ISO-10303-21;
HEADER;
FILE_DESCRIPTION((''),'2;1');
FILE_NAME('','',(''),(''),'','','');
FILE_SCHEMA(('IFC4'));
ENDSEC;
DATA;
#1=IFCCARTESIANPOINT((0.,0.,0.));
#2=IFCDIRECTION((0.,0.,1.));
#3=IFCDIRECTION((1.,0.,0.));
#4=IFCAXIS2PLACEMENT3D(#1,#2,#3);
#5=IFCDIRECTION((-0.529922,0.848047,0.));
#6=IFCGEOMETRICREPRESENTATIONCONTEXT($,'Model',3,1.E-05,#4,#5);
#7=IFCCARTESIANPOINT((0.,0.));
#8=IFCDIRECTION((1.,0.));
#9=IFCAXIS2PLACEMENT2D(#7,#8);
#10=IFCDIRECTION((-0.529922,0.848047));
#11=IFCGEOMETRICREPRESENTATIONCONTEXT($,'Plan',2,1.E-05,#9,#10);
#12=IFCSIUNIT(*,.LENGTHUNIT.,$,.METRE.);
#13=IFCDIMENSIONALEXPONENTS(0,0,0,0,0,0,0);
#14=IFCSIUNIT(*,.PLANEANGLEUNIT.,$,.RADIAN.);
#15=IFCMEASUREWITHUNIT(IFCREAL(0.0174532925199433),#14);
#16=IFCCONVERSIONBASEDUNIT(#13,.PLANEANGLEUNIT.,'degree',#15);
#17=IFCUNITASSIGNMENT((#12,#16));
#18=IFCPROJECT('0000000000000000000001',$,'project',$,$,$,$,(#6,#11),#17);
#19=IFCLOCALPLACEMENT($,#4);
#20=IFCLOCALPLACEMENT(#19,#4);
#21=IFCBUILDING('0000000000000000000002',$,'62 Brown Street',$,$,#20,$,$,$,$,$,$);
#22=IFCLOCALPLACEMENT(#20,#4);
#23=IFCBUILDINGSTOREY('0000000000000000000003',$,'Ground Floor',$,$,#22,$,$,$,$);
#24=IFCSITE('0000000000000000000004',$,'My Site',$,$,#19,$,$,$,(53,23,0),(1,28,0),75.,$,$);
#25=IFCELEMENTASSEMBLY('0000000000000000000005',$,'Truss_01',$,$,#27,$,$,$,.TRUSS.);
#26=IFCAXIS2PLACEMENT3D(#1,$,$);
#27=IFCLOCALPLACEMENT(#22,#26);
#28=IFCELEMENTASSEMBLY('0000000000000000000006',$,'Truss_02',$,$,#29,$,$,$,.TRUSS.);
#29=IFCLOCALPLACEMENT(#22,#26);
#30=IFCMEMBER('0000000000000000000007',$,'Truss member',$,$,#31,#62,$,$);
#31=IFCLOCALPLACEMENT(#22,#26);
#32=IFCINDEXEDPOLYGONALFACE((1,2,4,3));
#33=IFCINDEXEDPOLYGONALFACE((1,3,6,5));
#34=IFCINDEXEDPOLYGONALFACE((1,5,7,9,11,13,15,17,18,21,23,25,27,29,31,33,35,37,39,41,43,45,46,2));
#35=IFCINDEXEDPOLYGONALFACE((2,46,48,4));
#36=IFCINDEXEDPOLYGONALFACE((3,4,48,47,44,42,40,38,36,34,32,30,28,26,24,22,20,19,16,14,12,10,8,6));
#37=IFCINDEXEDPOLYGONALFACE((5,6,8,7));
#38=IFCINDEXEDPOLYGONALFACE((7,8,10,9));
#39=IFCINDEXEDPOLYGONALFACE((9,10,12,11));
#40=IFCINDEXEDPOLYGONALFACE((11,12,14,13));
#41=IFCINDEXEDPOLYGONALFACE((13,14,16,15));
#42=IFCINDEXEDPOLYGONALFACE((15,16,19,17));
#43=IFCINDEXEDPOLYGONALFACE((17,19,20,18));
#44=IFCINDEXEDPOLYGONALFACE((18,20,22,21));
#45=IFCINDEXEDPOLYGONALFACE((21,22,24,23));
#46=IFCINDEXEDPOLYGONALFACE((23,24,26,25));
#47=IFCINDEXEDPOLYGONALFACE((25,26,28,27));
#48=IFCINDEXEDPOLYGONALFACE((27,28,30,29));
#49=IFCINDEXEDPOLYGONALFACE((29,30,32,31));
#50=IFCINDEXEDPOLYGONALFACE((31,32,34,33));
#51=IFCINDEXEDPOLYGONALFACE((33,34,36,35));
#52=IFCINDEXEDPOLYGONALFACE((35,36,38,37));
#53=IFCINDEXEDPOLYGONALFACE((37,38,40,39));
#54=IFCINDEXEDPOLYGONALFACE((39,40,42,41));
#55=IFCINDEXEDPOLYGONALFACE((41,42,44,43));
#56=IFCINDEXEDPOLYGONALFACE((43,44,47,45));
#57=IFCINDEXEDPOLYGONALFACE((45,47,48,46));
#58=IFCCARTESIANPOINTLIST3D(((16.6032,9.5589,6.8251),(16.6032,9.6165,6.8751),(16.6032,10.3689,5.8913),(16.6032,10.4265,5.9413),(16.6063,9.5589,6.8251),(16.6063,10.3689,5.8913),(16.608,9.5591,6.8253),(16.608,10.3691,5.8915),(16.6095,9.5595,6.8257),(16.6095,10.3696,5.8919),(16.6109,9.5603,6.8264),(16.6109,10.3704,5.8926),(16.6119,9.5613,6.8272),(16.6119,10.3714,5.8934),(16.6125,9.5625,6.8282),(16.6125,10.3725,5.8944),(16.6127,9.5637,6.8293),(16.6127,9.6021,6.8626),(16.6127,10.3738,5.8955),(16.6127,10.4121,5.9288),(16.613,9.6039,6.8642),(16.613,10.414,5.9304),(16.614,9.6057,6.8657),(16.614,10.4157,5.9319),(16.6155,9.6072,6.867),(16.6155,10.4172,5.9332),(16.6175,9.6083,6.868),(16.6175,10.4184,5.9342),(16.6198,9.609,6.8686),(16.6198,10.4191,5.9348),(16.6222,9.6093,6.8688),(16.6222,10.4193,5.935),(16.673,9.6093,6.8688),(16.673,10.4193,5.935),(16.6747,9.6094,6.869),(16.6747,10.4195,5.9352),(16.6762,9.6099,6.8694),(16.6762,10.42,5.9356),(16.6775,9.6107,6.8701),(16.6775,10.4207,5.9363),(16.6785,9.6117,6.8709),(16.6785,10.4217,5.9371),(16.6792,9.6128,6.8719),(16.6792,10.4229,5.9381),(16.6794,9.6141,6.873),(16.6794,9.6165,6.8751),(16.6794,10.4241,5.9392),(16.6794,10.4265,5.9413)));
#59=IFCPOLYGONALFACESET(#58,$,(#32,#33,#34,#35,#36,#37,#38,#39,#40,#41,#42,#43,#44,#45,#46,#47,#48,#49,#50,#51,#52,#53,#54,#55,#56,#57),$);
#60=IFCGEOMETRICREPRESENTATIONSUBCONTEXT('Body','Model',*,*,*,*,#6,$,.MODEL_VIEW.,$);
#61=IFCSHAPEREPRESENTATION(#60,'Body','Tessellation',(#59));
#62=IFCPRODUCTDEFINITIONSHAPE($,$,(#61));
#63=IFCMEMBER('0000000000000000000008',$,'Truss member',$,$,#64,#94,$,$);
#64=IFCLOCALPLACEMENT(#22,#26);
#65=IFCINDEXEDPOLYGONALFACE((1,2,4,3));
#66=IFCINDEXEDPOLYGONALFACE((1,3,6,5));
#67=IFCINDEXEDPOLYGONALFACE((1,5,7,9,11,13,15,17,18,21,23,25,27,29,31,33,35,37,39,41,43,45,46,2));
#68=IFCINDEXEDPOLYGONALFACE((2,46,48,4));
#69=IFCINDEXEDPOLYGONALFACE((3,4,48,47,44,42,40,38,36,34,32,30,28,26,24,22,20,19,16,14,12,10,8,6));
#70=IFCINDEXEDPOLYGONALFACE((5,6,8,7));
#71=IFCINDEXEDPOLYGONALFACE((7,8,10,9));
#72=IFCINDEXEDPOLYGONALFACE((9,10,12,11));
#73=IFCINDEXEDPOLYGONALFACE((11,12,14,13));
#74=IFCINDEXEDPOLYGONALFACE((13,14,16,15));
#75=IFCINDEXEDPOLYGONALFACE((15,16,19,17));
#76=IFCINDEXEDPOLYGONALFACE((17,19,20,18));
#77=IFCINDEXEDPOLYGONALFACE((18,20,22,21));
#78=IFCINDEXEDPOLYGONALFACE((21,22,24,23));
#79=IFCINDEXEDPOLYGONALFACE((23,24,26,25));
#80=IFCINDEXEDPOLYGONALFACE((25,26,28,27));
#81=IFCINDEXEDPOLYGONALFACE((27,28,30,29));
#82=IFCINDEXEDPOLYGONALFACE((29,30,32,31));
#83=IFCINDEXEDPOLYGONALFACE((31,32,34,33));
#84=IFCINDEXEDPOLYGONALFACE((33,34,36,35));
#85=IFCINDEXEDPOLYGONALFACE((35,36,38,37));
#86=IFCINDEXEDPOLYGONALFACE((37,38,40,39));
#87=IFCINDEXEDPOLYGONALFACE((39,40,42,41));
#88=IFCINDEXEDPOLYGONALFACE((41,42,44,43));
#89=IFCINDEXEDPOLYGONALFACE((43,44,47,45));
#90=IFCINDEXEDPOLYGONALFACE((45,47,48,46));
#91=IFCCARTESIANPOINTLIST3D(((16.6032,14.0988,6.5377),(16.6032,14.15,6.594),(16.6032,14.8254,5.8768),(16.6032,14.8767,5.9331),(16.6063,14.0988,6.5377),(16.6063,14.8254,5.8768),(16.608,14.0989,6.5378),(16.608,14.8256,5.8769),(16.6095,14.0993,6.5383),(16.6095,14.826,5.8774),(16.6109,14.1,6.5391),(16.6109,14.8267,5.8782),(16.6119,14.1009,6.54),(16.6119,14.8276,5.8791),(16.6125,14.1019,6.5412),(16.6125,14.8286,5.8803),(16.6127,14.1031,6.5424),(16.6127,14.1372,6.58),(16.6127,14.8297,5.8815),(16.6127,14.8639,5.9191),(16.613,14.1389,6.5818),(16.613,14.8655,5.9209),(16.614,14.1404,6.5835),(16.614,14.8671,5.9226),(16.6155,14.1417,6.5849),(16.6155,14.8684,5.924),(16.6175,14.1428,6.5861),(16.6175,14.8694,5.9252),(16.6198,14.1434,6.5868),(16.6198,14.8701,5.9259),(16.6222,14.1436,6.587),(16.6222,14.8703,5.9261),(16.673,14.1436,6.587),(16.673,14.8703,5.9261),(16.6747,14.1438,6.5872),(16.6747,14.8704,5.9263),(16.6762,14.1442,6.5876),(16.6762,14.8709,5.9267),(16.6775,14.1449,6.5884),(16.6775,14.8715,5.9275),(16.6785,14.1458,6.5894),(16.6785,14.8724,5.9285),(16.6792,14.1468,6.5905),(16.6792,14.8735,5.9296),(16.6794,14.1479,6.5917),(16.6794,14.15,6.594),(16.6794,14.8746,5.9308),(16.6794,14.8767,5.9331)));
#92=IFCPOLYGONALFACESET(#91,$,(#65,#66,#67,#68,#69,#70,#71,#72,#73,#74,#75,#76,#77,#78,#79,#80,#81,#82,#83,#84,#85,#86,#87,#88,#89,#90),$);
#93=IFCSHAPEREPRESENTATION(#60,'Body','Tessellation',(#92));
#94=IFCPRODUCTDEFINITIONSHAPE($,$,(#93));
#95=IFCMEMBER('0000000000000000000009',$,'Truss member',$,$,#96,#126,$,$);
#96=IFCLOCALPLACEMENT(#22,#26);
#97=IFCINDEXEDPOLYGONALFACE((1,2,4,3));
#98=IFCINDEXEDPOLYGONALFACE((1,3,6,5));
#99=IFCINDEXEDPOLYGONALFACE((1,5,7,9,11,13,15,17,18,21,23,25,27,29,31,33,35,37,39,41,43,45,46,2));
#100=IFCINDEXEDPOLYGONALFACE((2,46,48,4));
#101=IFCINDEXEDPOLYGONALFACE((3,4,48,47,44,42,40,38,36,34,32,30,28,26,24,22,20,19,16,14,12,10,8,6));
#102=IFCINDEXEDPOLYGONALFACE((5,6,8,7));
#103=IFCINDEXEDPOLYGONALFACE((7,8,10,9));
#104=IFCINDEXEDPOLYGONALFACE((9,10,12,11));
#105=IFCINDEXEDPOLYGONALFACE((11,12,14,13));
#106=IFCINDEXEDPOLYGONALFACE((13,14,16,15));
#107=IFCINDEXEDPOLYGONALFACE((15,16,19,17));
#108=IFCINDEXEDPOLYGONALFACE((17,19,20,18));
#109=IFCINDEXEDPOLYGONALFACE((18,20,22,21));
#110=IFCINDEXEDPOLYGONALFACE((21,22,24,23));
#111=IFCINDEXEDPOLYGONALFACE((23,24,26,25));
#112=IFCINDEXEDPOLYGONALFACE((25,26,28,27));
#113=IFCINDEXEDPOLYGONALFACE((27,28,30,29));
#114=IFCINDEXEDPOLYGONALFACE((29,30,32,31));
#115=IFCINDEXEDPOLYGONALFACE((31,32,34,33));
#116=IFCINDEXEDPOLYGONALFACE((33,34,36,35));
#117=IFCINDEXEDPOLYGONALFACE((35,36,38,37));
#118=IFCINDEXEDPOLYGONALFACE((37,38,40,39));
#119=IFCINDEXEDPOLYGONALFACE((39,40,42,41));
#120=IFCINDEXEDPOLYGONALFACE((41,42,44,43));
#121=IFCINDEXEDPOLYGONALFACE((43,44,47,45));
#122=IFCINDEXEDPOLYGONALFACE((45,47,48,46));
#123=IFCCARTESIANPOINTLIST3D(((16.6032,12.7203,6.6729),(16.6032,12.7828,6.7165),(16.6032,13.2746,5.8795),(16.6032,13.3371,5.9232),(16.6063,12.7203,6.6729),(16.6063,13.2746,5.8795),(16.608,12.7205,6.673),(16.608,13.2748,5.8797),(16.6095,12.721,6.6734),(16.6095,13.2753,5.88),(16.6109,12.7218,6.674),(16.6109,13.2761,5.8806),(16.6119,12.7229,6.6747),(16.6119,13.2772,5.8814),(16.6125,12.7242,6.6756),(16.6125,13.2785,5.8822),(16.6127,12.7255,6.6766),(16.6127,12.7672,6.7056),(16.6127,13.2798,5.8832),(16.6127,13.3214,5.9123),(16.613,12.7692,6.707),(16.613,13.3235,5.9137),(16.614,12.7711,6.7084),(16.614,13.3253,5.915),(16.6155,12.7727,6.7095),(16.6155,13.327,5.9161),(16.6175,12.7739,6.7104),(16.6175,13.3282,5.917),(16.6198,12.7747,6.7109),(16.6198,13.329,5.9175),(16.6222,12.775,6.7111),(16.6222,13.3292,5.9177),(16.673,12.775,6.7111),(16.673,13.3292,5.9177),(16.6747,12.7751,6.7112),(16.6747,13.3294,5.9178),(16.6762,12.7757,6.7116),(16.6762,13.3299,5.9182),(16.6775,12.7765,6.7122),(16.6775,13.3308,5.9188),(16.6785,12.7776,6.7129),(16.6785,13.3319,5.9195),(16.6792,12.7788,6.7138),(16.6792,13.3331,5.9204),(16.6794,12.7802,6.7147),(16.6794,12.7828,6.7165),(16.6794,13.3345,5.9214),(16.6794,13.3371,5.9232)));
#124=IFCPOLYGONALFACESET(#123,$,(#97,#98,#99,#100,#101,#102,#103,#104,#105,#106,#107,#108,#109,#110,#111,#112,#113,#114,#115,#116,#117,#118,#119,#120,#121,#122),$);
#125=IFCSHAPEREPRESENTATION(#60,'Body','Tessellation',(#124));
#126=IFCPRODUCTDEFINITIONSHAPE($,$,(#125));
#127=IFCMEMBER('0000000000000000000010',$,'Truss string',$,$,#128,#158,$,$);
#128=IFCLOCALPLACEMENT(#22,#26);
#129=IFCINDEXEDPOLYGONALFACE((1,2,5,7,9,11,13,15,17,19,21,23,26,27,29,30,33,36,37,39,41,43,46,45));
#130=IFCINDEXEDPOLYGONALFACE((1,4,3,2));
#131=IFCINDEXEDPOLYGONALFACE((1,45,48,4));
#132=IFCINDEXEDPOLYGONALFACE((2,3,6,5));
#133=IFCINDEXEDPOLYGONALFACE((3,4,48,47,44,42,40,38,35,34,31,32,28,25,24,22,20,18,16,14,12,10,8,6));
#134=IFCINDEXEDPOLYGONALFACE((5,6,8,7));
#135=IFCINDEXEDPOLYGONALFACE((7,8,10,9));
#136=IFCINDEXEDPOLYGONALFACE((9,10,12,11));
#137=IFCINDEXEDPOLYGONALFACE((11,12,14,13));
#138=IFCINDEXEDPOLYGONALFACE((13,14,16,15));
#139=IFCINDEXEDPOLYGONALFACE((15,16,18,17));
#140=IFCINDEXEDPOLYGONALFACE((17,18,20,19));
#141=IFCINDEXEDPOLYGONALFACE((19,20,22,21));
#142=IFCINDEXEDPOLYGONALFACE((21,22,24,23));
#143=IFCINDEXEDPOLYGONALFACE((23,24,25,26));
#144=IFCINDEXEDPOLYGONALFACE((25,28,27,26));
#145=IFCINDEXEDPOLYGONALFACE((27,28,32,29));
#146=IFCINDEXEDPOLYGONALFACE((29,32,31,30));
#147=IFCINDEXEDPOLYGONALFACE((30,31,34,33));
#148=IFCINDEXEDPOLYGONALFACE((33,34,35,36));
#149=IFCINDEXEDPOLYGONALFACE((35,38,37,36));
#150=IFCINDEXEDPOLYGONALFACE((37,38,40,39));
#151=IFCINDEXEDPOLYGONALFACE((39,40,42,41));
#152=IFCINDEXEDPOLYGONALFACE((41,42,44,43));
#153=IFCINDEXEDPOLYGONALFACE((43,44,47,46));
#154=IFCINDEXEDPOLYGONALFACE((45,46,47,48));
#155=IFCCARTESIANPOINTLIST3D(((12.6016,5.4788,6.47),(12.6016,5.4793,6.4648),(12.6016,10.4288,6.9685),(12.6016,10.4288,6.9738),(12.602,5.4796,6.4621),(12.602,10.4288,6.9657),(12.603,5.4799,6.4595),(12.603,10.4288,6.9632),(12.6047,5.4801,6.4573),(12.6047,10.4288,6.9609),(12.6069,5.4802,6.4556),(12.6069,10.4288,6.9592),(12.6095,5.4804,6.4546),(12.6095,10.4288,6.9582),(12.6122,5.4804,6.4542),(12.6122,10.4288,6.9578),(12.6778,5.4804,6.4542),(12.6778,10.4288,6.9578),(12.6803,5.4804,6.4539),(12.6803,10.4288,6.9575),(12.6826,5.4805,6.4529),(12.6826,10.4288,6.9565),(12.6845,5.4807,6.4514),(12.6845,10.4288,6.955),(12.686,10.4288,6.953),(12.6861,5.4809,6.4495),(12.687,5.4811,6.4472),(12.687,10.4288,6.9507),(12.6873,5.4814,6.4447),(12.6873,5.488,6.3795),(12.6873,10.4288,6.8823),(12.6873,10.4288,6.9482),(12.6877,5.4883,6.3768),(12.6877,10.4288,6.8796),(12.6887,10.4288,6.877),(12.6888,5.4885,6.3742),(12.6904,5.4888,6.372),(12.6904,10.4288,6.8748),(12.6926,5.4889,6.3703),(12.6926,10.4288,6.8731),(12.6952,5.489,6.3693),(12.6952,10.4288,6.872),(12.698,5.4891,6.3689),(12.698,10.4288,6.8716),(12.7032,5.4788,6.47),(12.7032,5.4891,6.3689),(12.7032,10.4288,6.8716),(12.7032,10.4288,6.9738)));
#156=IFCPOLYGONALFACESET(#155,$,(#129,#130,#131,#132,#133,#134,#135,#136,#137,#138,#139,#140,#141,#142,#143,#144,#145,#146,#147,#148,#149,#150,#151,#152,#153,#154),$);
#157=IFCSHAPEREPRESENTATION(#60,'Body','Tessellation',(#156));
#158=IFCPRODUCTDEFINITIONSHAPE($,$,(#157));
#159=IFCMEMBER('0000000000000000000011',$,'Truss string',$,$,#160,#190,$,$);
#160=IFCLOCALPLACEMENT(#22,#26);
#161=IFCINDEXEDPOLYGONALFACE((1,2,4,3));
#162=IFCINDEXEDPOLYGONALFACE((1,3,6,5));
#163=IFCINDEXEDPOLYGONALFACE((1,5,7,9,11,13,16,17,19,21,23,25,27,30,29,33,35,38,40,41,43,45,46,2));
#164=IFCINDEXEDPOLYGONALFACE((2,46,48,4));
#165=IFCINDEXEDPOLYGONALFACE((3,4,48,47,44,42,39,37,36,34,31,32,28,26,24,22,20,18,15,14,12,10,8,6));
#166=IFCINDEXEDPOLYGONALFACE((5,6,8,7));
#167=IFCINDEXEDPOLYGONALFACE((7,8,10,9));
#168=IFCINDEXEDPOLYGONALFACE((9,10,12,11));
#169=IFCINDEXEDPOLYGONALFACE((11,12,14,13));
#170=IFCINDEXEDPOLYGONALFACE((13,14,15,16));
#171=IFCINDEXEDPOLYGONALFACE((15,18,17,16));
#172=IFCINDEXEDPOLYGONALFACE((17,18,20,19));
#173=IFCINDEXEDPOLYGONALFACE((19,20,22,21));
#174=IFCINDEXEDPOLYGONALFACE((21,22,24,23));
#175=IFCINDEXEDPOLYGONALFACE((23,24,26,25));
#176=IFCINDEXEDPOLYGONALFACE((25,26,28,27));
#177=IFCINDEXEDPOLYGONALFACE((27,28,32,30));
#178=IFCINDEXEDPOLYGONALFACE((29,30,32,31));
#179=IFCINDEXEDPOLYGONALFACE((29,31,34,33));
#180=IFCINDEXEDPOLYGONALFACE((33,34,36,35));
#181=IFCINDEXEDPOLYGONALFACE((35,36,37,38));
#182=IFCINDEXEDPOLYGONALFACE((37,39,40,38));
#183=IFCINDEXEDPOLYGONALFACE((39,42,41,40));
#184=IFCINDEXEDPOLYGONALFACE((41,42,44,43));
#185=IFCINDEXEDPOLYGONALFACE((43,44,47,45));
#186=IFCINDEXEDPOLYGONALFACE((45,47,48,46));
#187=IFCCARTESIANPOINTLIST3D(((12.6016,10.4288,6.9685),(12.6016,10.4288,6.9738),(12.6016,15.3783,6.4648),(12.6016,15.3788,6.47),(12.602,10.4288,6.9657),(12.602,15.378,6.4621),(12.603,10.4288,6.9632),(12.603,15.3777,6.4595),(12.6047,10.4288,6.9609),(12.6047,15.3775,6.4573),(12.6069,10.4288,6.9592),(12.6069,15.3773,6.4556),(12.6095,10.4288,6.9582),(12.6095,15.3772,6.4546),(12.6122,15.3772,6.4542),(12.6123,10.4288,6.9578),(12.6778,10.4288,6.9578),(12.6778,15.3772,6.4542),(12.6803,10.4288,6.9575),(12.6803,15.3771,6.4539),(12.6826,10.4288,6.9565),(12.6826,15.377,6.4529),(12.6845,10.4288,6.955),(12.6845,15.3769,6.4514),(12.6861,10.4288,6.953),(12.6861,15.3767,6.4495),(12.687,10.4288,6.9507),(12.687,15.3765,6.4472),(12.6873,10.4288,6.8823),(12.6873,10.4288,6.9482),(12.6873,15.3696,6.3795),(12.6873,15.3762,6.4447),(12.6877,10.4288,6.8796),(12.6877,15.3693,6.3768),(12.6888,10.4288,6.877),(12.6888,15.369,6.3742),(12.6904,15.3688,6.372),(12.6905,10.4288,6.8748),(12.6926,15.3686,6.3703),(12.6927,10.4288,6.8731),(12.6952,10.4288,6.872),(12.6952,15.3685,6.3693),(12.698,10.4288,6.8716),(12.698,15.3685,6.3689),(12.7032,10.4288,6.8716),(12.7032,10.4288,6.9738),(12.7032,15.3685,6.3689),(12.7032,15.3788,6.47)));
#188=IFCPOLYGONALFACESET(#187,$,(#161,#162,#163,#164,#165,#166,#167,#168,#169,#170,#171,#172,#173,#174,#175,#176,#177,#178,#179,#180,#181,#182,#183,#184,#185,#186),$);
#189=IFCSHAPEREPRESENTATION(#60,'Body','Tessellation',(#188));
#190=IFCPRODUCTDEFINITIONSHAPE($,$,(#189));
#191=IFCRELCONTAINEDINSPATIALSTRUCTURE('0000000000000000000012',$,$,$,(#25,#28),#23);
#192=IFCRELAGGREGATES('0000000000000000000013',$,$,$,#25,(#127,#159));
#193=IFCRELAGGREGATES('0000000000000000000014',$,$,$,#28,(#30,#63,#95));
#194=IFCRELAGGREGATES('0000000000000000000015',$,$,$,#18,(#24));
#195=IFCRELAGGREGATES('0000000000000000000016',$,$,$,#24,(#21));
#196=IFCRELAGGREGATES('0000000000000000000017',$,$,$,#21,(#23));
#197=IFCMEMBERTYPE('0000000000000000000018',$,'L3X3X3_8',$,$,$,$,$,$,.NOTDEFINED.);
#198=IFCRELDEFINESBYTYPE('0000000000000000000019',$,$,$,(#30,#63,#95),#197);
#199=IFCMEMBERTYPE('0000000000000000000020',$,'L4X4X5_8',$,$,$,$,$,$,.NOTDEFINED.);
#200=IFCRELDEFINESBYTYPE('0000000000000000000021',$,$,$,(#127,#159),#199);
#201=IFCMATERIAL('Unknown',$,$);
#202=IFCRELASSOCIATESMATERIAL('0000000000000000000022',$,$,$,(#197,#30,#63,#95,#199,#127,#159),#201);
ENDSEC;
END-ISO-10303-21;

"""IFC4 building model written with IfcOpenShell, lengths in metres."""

from ifc_helpers import new_model, entity, si_unit, converted_unit, direction, frame, origin_with_axes, origin_2d_with_axis, place, context, subcontext, project, spatial, l_section, extrude, clip, halfspace, material, material_profile, profile_set, profile_usage, type_object, element, aggregate, save


model = new_model("IFC4")

# Units and contexts
model_context = context("Model", 3, precision=1e-05, world=origin_with_axes(), true_north=direction((-0.529922, 0.848047, 0.0)))
plan_context = context("Plan", 2, precision=1e-05, world=origin_2d_with_axis(), true_north=direction((-0.529922, 0.848047)))
body_context = subcontext(model_context, "Body", "Model", "MODEL_VIEW")
ifc_project = project(units=[si_unit("LENGTHUNIT", "METRE"), converted_unit("PLANEANGLEUNIT", "degree", entity("IfcReal", 0.0174532925199433), si_unit("PLANEANGLEUNIT", "RADIAN"), dimensions=[0, 0, 0, 0, 0, 0, 0])], contexts=[model_context, plan_context])

# Site, building, storey
site_placement = place(None, origin_with_axes())
site = spatial("IfcSite", under=ifc_project, at=site_placement, Name="My Site", RefLatitude=(53, 23, 0), RefLongitude=(1, 28, 0), RefElevation=75.0)
building_placement = place(site_placement, origin_with_axes())
building = spatial("IfcBuilding", under=site, at=building_placement, Name="62 Brown Street")
storey_placement = place(building_placement, origin_with_axes())
storey = spatial("IfcBuildingStorey", under=building, at=storey_placement, Name="Ground Floor")

# Element assemblies, members
ifc_material_1 = material(Name="Unknown")
ifc_material_profile_1 = material_profile(ifc_material_1, l_section(Depth=0.0762, Width=0.0762, Thickness=0.0095, FilletRadius=0.0095, EdgeRadius=0.0064))
ifc_profile_set_1 = profile_set([ifc_material_profile_1])
member_type_1 = type_object("IfcMemberType", Name="L3X3X3_8", PredefinedType="NOTDEFINED", material=ifc_profile_set_1)
assembly_1_placement = place(storey_placement, frame((12.7032, 10.4288, 6.9738), z_axis=(0.0, 0.0, 1.0), x_axis=(1.0, 0.0, 0.0)))
assembly_1 = element("IfcElementAssembly", 1, at=assembly_1_placement, inside=storey, Name="Truss_01", PredefinedType="TRUSS")
assembly_2_placement = place(storey_placement, frame((16.6032, 10.4288, 6.9738), z_axis=(0.0, 0.0, 1.0), x_axis=(1.0, 0.0, 0.0)))
assembly_2 = element("IfcElementAssembly", 2, at=assembly_2_placement, inside=storey, Name="Truss_02", PredefinedType="TRUSS")
ifc_profile_usage_1 = profile_usage(ifc_profile_set_1, cardinal=5)
member_1_placement = place(assembly_2_placement, frame((0.0381, -0.8411, -0.1236), z_axis=(-0.000001, 0.655276, -0.755389), x_axis=(1.0, 0.000001, 0.0)))
member_1 = element("IfcMember", 3, at=member_1_placement, type_object=member_type_1, material=ifc_profile_usage_1, Name="Truss member", context=body_context, shape_type="SweptSolid", body=[
    extrude(l_section(Depth=0.0762, Width=0.0762, Thickness=0.0095, FilletRadius=0.0095, EdgeRadius=0.0064), origin_with_axes(), (0.0, 0.0, 1.0), 1.2362),
])
ifc_profile_usage_2 = profile_usage(ifc_profile_set_1, cardinal=5)
member_2_placement = place(assembly_2_placement, frame((0.0381, 3.6956, -0.4079), z_axis=(-0.000001, 0.739785, -0.672843), x_axis=(1.0, 0.000001, 0.0)))
member_2 = element("IfcMember", 4, at=member_2_placement, type_object=member_type_1, material=ifc_profile_usage_2, Name="Truss member", context=body_context, shape_type="SweptSolid", body=[
    extrude(l_section(Depth=0.0762, Width=0.0762, Thickness=0.0095, FilletRadius=0.0095, EdgeRadius=0.0064), origin_with_axes(), (0.0, 0.0, 1.0), 0.9823),
])
ifc_profile_usage_3 = profile_usage(ifc_profile_set_1, cardinal=5)
member_3_placement = place(assembly_2_placement, frame((0.0381, 2.3228, -0.279), z_axis=(-0.000001, 0.572709, -0.819759), x_axis=(1.0, 0.0, 0.0)))
member_3 = element("IfcMember", 5, at=member_3_placement, type_object=member_type_1, material=ifc_profile_usage_3, Name="Truss member", context=body_context, shape_type="SweptSolid", body=[
    extrude(l_section(Depth=0.0762, Width=0.0762, Thickness=0.0095, FilletRadius=0.0095, EdgeRadius=0.0064), origin_with_axes(), (0.0, 0.0, 1.0), 0.9678),
])

# Members
ifc_material_profile_2 = material_profile(ifc_material_1, l_section(Depth=0.1016, Width=0.1016, Thickness=0.0159, FilletRadius=0.0095, EdgeRadius=0.0106))
ifc_profile_set_2 = profile_set([ifc_material_profile_2])
ifc_profile_usage_4 = profile_usage(ifc_profile_set_2, cardinal=5)
member_type_2 = type_object("IfcMemberType", Name="L4X4X5_8", PredefinedType="NOTDEFINED", material=ifc_profile_set_2)
member_4_placement = place(assembly_1_placement, frame((-0.0508, 0.3519, -0.0152), z_axis=(0.000001, -0.994861, -0.101247), x_axis=(-1.0, -0.000001, 0.0)))
member_4 = element("IfcMember", 6, at=member_4_placement, type_object=member_type_2, material=ifc_profile_usage_4, Name="Truss string", context=body_context, shape_type="Clipping", body=[
    clip(extrude(l_section(Depth=0.1016, Width=0.1016, Thickness=0.0159, FilletRadius=0.0095, EdgeRadius=0.0106), origin_with_axes(), (0.0, 0.0, 1.0), 5.3242), halfspace(frame((16.4524, -0.0508, 0.3486), z_axis=(0.0, 0.101247, -0.994861), x_axis=(1.0, -0.000001, 0.0)), False)),
])
ifc_profile_usage_5 = profile_usage(ifc_profile_set_2, cardinal=5)
member_5_placement = place(assembly_1_placement, frame((-0.0508, 4.9449, -0.5543), z_axis=(0.000001, -0.994861, 0.101247), x_axis=(-1.0, -0.000001, 0.0)))
member_5 = element("IfcMember", 7, at=member_5_placement, type_object=member_type_2, material=ifc_profile_usage_5, Name="Truss string", context=body_context, shape_type="Clipping", body=[
    clip(extrude(l_section(Depth=0.1016, Width=0.1016, Thickness=0.0159, FilletRadius=0.0095, EdgeRadius=0.0106), origin_with_axes(), (0.0, 0.0, 1.0), 5.3242), halfspace(frame((16.4524, -0.0508, 4.9756), z_axis=(0.0, 0.101247, 0.994861), x_axis=(1.0, -0.000001, 0.0)), False)),
])
aggregate(assembly_1, [member_4, member_5])
aggregate(assembly_2, [member_1, member_2, member_3])

save(model, "model.ifc")
